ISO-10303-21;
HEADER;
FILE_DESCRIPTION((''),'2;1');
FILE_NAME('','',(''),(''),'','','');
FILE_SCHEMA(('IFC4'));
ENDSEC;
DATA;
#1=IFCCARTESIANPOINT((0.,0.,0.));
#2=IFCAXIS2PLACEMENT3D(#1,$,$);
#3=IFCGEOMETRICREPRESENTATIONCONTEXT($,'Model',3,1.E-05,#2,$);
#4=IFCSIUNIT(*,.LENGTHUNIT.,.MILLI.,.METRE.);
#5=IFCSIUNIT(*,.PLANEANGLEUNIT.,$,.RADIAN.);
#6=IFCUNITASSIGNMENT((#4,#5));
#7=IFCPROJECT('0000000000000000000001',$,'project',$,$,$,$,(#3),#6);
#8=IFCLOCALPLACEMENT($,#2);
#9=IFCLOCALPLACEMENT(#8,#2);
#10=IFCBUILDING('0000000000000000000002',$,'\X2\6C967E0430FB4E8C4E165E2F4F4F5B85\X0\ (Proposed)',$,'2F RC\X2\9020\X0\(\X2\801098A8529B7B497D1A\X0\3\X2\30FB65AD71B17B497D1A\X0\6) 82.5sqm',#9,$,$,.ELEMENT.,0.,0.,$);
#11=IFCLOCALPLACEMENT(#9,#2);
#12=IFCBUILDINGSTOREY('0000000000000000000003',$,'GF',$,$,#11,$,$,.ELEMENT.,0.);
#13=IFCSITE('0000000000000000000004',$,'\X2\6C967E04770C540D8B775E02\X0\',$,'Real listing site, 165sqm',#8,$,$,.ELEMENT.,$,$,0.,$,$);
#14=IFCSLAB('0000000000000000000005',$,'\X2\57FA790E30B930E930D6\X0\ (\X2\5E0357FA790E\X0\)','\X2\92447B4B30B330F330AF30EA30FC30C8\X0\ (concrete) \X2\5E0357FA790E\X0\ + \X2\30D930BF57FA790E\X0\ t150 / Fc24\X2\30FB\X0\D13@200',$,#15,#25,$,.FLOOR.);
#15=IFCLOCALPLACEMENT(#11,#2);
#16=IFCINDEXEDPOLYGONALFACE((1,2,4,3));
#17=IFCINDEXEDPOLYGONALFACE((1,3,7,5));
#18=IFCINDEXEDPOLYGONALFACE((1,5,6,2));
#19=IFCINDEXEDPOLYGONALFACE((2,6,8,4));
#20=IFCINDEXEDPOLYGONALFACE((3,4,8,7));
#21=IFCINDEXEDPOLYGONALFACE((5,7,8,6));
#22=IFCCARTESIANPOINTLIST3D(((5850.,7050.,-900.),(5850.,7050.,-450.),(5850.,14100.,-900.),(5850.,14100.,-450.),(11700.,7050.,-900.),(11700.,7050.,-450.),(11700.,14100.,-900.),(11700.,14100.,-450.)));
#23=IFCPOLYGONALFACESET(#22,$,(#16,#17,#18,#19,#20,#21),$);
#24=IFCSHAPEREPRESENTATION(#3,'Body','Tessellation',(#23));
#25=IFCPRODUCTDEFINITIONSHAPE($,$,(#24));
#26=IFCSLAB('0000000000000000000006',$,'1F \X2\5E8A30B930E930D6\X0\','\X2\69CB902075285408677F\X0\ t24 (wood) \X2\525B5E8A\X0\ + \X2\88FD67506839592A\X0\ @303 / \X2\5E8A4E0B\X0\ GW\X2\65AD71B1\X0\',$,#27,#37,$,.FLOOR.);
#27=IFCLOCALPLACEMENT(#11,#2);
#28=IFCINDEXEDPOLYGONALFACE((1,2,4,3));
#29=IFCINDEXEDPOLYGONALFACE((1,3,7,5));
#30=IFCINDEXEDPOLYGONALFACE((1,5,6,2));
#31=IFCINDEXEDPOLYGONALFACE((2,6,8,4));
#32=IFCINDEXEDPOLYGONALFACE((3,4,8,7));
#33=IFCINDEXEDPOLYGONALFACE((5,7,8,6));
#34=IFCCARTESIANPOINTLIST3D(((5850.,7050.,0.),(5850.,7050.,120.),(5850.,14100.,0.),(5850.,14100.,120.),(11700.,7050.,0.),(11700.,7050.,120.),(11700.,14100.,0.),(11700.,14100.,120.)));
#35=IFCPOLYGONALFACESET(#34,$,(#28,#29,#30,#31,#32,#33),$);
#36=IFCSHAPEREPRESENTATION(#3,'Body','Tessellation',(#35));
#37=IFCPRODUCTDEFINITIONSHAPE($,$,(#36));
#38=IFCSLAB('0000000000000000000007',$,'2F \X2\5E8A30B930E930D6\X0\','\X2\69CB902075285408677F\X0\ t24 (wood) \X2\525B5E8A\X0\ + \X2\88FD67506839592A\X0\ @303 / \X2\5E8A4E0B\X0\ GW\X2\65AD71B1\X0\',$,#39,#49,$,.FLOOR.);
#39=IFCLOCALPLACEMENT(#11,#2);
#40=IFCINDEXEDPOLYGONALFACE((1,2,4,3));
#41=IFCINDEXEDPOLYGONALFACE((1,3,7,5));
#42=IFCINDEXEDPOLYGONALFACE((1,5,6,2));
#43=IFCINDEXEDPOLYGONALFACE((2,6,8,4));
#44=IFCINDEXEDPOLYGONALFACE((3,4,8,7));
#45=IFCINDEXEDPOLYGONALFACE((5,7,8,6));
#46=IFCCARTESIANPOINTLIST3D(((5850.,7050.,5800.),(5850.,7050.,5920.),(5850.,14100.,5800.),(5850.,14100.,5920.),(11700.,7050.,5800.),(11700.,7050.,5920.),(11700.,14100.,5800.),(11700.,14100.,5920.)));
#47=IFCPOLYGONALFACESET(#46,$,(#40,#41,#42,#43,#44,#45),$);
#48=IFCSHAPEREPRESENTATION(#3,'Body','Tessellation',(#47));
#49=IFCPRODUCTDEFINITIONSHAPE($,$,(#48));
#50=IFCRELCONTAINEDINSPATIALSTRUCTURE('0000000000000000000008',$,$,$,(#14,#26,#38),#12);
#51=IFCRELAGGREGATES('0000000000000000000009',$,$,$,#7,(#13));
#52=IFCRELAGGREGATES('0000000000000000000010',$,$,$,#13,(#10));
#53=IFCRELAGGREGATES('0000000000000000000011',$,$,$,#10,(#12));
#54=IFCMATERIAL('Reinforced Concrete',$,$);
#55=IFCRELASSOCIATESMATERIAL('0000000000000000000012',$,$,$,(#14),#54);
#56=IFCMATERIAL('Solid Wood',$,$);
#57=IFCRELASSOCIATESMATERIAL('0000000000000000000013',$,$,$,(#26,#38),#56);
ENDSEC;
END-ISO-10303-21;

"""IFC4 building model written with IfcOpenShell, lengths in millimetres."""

from ifc_helpers import new_model, si_unit, frame, frame_2d, origin, place, context, project, spatial, rectangle, extrude, material, element, save


model = new_model("IFC4")

# Units and contexts
model_context = context("Model", 3, precision=1e-05, world=origin())
ifc_project = project(units=[si_unit("LENGTHUNIT", "METRE", prefix="MILLI"), si_unit("PLANEANGLEUNIT", "RADIAN")], contexts=[model_context])

# Site, building, storey
site_placement = place(None, origin())
site = spatial("IfcSite", under=ifc_project, at=site_placement, Name="沖縄県名護市", ObjectType="Real listing site, 165sqm", CompositionType="ELEMENT", RefElevation=0.0)
building_placement = place(site_placement, origin())
building = spatial("IfcBuilding", under=site, at=building_placement, Name="沖縄・二世帯住宅 (Proposed)", ObjectType="2F RC造(耐風力等級3・断熱等級6) 82.5sqm", CompositionType="ELEMENT", ElevationOfRefHeight=0.0, ElevationOfTerrain=0.0)
storey_placement = place(building_placement, origin())
storey = spatial("IfcBuildingStorey", under=building, at=storey_placement, Name="GF", CompositionType="ELEMENT", Elevation=0.0)

# Shared definitions
ifc_material_1 = material(Name="Solid Wood")

# Slabs
ifc_material_2 = material(Name="Reinforced Concrete")
slab_1_placement = place(storey_placement, frame((2925.0, 3525.0, -450.0)))
element("IfcSlab", 1, at=slab_1_placement, inside=storey, material=ifc_material_2, Name="基礎スラブ (布基礎)", Description="鉄筋コンクリート (concrete) 布基礎 + ベタ基礎 t150 / Fc24・D13@200", PredefinedType="FLOOR", context=model_context, shape_type="SweptSolid", body=[
    extrude(rectangle(XDim=5850.0, YDim=7050.0, at=frame_2d((2925.0, 3525.0))), frame((2925.0, 3525.0, -450.0)), (0.0, 0.0, 1.0), 450.0),
])
slab_2_placement = place(storey_placement, frame((2925.0, 3525.0, 0.0)))
element("IfcSlab", 2, at=slab_2_placement, inside=storey, material=ifc_material_1, Name="1F 床スラブ", Description="構造用合板 t24 (wood) 剛床 + 製材根太 @303 / 床下 GW断熱", PredefinedType="FLOOR", context=model_context, shape_type="SweptSolid", body=[
    extrude(rectangle(XDim=5850.0, YDim=7050.0, at=frame_2d((2925.0, 3525.0))), frame((2925.0, 3525.0, 0.0)), (0.0, 0.0, 1.0), 120.0),
])
slab_3_placement = place(storey_placement, frame((2925.0, 3525.0, 2900.0)))
element("IfcSlab", 3, at=slab_3_placement, inside=storey, material=ifc_material_1, Name="2F 床スラブ", Description="構造用合板 t24 (wood) 剛床 + 製材根太 @303 / 床下 GW断熱", PredefinedType="FLOOR", context=model_context, shape_type="SweptSolid", body=[
    extrude(rectangle(XDim=5850.0, YDim=7050.0, at=frame_2d((2925.0, 3525.0))), frame((2925.0, 3525.0, 2900.0)), (0.0, 0.0, 1.0), 120.0),
])

save(model, "model.ifc")
